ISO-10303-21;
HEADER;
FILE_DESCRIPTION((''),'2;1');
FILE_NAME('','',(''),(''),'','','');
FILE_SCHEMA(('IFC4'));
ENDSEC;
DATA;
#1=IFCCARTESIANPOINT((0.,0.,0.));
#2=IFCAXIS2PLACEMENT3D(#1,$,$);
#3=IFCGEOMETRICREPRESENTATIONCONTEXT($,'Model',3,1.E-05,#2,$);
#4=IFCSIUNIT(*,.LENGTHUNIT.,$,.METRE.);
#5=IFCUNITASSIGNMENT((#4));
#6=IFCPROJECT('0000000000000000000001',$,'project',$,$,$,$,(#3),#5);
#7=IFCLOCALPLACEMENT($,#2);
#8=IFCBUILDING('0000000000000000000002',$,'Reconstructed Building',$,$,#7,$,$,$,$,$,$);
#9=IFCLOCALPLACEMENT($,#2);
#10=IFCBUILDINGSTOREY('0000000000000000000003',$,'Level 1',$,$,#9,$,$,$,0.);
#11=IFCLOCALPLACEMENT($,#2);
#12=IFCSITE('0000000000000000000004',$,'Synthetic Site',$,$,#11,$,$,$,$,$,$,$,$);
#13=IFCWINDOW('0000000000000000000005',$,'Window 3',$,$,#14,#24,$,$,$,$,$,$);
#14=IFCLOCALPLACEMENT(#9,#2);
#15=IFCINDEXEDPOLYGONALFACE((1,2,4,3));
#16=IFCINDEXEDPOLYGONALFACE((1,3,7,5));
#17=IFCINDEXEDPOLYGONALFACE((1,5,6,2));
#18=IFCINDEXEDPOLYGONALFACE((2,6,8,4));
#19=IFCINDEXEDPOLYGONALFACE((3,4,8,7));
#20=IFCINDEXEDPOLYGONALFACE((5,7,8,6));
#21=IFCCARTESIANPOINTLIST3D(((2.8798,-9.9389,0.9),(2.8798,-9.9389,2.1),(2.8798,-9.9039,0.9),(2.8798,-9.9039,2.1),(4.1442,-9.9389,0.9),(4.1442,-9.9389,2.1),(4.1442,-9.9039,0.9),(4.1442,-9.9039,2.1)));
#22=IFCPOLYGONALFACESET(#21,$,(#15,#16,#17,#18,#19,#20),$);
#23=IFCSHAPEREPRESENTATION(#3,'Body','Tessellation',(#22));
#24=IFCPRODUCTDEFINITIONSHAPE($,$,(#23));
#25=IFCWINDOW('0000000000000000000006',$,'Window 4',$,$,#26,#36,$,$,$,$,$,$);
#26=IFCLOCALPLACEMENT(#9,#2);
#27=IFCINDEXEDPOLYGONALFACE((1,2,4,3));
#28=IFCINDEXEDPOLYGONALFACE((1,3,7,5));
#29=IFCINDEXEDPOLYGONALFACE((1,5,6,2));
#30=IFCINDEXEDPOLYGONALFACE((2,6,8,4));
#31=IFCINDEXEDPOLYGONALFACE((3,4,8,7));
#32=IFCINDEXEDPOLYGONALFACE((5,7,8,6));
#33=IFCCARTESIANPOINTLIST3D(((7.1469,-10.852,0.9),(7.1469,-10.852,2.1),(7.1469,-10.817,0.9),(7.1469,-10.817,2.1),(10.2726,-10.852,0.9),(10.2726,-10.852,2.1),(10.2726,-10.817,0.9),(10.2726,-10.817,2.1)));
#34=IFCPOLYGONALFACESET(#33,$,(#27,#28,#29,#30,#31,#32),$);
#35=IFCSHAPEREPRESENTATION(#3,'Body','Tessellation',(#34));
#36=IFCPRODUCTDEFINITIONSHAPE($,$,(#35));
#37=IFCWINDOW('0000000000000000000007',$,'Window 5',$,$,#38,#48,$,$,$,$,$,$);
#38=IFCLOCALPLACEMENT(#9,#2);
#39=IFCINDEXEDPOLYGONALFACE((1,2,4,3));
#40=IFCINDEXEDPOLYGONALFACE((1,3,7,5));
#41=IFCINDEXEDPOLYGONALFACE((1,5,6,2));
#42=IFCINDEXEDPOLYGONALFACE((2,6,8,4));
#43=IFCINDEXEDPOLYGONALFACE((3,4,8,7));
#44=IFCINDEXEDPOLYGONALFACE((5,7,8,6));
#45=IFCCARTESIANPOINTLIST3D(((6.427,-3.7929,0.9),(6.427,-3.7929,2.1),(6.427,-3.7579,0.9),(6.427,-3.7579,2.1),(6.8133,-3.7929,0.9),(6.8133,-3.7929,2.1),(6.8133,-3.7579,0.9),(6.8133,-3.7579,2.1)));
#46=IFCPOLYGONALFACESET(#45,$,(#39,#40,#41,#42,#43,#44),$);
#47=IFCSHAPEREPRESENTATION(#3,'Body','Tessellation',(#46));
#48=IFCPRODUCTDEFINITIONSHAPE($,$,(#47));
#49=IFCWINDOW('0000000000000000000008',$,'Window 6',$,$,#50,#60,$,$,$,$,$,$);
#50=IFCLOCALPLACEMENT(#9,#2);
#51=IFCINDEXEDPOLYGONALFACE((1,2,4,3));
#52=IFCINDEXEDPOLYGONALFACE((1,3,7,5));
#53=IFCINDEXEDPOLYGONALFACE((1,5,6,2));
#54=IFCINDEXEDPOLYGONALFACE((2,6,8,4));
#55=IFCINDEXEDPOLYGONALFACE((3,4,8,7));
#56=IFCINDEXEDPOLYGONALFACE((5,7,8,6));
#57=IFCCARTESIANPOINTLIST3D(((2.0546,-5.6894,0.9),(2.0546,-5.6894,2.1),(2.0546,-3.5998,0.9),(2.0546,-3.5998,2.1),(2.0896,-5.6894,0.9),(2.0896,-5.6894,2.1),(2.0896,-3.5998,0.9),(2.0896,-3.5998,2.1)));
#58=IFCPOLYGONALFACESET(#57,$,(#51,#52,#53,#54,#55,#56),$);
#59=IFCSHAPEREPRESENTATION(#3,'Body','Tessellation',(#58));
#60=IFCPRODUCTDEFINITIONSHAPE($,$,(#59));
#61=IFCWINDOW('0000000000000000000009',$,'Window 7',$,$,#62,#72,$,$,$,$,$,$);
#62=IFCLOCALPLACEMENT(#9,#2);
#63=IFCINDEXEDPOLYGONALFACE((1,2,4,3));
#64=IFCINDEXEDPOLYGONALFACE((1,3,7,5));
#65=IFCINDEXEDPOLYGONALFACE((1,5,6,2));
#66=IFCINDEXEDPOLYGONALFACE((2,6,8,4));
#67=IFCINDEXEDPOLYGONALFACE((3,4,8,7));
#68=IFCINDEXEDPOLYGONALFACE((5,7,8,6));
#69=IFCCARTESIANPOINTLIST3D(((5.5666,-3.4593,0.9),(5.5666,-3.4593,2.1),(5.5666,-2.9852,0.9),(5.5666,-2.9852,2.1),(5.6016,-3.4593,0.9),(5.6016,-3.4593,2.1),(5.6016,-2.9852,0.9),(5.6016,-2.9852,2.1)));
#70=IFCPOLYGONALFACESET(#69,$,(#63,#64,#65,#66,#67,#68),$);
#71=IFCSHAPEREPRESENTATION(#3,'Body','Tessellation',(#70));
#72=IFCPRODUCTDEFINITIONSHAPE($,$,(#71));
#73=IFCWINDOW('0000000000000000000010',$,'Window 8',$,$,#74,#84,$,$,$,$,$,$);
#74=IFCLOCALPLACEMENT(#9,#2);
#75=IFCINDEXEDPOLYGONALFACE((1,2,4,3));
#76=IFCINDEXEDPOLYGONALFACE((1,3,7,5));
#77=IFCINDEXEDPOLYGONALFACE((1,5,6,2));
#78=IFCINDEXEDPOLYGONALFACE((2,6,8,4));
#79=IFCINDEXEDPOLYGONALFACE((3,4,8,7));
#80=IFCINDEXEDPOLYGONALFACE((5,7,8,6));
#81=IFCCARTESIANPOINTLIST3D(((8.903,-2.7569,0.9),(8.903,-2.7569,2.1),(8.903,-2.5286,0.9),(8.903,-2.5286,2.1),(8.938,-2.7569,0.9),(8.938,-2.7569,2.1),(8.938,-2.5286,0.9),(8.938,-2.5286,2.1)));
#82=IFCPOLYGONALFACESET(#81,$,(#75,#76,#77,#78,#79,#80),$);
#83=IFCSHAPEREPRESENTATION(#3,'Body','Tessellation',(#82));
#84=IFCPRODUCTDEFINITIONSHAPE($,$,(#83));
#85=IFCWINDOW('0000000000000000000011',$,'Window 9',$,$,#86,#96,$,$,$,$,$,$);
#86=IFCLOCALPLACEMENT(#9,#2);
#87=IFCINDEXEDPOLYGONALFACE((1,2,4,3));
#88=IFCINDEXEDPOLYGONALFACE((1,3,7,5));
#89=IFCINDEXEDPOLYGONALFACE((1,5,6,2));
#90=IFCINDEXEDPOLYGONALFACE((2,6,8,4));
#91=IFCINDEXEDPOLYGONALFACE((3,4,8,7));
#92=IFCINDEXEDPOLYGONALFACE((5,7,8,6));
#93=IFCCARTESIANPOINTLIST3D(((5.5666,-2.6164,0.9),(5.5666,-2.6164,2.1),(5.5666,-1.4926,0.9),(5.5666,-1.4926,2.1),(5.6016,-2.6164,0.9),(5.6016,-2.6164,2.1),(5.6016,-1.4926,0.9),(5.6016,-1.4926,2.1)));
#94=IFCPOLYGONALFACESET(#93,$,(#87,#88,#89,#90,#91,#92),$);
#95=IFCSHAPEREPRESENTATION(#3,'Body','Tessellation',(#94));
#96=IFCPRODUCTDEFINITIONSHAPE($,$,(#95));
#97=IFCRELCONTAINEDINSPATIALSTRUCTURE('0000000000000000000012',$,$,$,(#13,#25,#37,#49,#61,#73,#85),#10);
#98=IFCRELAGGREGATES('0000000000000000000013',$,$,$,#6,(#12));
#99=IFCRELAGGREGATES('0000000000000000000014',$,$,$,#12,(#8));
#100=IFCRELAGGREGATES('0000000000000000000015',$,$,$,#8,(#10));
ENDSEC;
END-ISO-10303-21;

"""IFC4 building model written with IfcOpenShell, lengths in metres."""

from ifc_helpers import new_model, si_unit, frame, origin, place, context, project, spatial, polyline, outline, extrude, element, save


model = new_model("IFC4")

# Units and contexts
model_context = context("Model", 3, precision=1e-05, world=origin())
ifc_project = project(units=[si_unit("LENGTHUNIT", "METRE")], contexts=[model_context])

# Site, building, storey
site_placement = place(None, origin())
site = spatial("IfcSite", under=ifc_project, at=site_placement, Name="Synthetic Site")
building_placement = place(None, origin())
building = spatial("IfcBuilding", under=site, at=building_placement, Name="Reconstructed Building")
storey_placement = place(None, origin())
storey = spatial("IfcBuildingStorey", under=building, at=storey_placement, Name="Level 1", Elevation=0.0)

# Windows
window_1_placement = place(None, origin())
element("IfcWindow", 1, at=window_1_placement, inside=storey, Name="Window 3", context=model_context, shape_type="SweptSolid", body=[
    extrude(outline(polyline([(4.1442, -9.9039), (2.8798, -9.9039), (2.8798, -9.9389), (4.1442, -9.9389), (4.1442, -9.9039)])), frame((0.0, 0.0, 0.9), z_axis=(0.0, 0.0, 1.0)), (0.0, 0.0, 1.0), 1.2),
])
window_2_placement = place(None, origin())
element("IfcWindow", 2, at=window_2_placement, inside=storey, Name="Window 4", context=model_context, shape_type="SweptSolid", body=[
    extrude(outline(polyline([(10.2726, -10.817), (7.1469, -10.817), (7.1469, -10.852), (10.2726, -10.852), (10.2726, -10.817)])), frame((0.0, 0.0, 0.9), z_axis=(0.0, 0.0, 1.0)), (0.0, 0.0, 1.0), 1.2),
])
window_3_placement = place(None, origin())
element("IfcWindow", 3, at=window_3_placement, inside=storey, Name="Window 5", context=model_context, shape_type="SweptSolid", body=[
    extrude(outline(polyline([(6.8133, -3.7579), (6.427, -3.7579), (6.427, -3.7929), (6.8133, -3.7929), (6.8133, -3.7579)])), frame((0.0, 0.0, 0.9), z_axis=(0.0, 0.0, 1.0)), (0.0, 0.0, 1.0), 1.2),
])
window_4_placement = place(None, origin())
element("IfcWindow", 4, at=window_4_placement, inside=storey, Name="Window 6", context=model_context, shape_type="SweptSolid", body=[
    extrude(outline(polyline([(2.0546, -3.5998), (2.0546, -5.6894), (2.0896, -5.6894), (2.0896, -3.5998), (2.0546, -3.5998)])), frame((0.0, 0.0, 0.9), z_axis=(0.0, 0.0, 1.0)), (0.0, 0.0, 1.0), 1.2),
])
window_5_placement = place(None, origin())
element("IfcWindow", 5, at=window_5_placement, inside=storey, Name="Window 7", context=model_context, shape_type="SweptSolid", body=[
    extrude(outline(polyline([(5.5666, -2.9852), (5.5666, -3.4593), (5.6016, -3.4593), (5.6016, -2.9852), (5.5666, -2.9852)])), frame((0.0, 0.0, 0.9), z_axis=(0.0, 0.0, 1.0)), (0.0, 0.0, 1.0), 1.2),
])
window_6_placement = place(None, origin())
element("IfcWindow", 6, at=window_6_placement, inside=storey, Name="Window 8", context=model_context, shape_type="SweptSolid", body=[
    extrude(outline(polyline([(8.903, -2.5286), (8.903, -2.7569), (8.938, -2.7569), (8.938, -2.5286), (8.903, -2.5286)])), frame((0.0, 0.0, 0.9), z_axis=(0.0, 0.0, 1.0)), (0.0, 0.0, 1.0), 1.2),
])
window_7_placement = place(None, origin())
element("IfcWindow", 7, at=window_7_placement, inside=storey, Name="Window 9", context=model_context, shape_type="SweptSolid", body=[
    extrude(outline(polyline([(5.5666, -1.4926), (5.5666, -2.6164), (5.6016, -2.6164), (5.6016, -1.4926), (5.5666, -1.4926)])), frame((0.0, 0.0, 0.9), z_axis=(0.0, 0.0, 1.0)), (0.0, 0.0, 1.0), 1.2),
])

save(model, "model.ifc")
